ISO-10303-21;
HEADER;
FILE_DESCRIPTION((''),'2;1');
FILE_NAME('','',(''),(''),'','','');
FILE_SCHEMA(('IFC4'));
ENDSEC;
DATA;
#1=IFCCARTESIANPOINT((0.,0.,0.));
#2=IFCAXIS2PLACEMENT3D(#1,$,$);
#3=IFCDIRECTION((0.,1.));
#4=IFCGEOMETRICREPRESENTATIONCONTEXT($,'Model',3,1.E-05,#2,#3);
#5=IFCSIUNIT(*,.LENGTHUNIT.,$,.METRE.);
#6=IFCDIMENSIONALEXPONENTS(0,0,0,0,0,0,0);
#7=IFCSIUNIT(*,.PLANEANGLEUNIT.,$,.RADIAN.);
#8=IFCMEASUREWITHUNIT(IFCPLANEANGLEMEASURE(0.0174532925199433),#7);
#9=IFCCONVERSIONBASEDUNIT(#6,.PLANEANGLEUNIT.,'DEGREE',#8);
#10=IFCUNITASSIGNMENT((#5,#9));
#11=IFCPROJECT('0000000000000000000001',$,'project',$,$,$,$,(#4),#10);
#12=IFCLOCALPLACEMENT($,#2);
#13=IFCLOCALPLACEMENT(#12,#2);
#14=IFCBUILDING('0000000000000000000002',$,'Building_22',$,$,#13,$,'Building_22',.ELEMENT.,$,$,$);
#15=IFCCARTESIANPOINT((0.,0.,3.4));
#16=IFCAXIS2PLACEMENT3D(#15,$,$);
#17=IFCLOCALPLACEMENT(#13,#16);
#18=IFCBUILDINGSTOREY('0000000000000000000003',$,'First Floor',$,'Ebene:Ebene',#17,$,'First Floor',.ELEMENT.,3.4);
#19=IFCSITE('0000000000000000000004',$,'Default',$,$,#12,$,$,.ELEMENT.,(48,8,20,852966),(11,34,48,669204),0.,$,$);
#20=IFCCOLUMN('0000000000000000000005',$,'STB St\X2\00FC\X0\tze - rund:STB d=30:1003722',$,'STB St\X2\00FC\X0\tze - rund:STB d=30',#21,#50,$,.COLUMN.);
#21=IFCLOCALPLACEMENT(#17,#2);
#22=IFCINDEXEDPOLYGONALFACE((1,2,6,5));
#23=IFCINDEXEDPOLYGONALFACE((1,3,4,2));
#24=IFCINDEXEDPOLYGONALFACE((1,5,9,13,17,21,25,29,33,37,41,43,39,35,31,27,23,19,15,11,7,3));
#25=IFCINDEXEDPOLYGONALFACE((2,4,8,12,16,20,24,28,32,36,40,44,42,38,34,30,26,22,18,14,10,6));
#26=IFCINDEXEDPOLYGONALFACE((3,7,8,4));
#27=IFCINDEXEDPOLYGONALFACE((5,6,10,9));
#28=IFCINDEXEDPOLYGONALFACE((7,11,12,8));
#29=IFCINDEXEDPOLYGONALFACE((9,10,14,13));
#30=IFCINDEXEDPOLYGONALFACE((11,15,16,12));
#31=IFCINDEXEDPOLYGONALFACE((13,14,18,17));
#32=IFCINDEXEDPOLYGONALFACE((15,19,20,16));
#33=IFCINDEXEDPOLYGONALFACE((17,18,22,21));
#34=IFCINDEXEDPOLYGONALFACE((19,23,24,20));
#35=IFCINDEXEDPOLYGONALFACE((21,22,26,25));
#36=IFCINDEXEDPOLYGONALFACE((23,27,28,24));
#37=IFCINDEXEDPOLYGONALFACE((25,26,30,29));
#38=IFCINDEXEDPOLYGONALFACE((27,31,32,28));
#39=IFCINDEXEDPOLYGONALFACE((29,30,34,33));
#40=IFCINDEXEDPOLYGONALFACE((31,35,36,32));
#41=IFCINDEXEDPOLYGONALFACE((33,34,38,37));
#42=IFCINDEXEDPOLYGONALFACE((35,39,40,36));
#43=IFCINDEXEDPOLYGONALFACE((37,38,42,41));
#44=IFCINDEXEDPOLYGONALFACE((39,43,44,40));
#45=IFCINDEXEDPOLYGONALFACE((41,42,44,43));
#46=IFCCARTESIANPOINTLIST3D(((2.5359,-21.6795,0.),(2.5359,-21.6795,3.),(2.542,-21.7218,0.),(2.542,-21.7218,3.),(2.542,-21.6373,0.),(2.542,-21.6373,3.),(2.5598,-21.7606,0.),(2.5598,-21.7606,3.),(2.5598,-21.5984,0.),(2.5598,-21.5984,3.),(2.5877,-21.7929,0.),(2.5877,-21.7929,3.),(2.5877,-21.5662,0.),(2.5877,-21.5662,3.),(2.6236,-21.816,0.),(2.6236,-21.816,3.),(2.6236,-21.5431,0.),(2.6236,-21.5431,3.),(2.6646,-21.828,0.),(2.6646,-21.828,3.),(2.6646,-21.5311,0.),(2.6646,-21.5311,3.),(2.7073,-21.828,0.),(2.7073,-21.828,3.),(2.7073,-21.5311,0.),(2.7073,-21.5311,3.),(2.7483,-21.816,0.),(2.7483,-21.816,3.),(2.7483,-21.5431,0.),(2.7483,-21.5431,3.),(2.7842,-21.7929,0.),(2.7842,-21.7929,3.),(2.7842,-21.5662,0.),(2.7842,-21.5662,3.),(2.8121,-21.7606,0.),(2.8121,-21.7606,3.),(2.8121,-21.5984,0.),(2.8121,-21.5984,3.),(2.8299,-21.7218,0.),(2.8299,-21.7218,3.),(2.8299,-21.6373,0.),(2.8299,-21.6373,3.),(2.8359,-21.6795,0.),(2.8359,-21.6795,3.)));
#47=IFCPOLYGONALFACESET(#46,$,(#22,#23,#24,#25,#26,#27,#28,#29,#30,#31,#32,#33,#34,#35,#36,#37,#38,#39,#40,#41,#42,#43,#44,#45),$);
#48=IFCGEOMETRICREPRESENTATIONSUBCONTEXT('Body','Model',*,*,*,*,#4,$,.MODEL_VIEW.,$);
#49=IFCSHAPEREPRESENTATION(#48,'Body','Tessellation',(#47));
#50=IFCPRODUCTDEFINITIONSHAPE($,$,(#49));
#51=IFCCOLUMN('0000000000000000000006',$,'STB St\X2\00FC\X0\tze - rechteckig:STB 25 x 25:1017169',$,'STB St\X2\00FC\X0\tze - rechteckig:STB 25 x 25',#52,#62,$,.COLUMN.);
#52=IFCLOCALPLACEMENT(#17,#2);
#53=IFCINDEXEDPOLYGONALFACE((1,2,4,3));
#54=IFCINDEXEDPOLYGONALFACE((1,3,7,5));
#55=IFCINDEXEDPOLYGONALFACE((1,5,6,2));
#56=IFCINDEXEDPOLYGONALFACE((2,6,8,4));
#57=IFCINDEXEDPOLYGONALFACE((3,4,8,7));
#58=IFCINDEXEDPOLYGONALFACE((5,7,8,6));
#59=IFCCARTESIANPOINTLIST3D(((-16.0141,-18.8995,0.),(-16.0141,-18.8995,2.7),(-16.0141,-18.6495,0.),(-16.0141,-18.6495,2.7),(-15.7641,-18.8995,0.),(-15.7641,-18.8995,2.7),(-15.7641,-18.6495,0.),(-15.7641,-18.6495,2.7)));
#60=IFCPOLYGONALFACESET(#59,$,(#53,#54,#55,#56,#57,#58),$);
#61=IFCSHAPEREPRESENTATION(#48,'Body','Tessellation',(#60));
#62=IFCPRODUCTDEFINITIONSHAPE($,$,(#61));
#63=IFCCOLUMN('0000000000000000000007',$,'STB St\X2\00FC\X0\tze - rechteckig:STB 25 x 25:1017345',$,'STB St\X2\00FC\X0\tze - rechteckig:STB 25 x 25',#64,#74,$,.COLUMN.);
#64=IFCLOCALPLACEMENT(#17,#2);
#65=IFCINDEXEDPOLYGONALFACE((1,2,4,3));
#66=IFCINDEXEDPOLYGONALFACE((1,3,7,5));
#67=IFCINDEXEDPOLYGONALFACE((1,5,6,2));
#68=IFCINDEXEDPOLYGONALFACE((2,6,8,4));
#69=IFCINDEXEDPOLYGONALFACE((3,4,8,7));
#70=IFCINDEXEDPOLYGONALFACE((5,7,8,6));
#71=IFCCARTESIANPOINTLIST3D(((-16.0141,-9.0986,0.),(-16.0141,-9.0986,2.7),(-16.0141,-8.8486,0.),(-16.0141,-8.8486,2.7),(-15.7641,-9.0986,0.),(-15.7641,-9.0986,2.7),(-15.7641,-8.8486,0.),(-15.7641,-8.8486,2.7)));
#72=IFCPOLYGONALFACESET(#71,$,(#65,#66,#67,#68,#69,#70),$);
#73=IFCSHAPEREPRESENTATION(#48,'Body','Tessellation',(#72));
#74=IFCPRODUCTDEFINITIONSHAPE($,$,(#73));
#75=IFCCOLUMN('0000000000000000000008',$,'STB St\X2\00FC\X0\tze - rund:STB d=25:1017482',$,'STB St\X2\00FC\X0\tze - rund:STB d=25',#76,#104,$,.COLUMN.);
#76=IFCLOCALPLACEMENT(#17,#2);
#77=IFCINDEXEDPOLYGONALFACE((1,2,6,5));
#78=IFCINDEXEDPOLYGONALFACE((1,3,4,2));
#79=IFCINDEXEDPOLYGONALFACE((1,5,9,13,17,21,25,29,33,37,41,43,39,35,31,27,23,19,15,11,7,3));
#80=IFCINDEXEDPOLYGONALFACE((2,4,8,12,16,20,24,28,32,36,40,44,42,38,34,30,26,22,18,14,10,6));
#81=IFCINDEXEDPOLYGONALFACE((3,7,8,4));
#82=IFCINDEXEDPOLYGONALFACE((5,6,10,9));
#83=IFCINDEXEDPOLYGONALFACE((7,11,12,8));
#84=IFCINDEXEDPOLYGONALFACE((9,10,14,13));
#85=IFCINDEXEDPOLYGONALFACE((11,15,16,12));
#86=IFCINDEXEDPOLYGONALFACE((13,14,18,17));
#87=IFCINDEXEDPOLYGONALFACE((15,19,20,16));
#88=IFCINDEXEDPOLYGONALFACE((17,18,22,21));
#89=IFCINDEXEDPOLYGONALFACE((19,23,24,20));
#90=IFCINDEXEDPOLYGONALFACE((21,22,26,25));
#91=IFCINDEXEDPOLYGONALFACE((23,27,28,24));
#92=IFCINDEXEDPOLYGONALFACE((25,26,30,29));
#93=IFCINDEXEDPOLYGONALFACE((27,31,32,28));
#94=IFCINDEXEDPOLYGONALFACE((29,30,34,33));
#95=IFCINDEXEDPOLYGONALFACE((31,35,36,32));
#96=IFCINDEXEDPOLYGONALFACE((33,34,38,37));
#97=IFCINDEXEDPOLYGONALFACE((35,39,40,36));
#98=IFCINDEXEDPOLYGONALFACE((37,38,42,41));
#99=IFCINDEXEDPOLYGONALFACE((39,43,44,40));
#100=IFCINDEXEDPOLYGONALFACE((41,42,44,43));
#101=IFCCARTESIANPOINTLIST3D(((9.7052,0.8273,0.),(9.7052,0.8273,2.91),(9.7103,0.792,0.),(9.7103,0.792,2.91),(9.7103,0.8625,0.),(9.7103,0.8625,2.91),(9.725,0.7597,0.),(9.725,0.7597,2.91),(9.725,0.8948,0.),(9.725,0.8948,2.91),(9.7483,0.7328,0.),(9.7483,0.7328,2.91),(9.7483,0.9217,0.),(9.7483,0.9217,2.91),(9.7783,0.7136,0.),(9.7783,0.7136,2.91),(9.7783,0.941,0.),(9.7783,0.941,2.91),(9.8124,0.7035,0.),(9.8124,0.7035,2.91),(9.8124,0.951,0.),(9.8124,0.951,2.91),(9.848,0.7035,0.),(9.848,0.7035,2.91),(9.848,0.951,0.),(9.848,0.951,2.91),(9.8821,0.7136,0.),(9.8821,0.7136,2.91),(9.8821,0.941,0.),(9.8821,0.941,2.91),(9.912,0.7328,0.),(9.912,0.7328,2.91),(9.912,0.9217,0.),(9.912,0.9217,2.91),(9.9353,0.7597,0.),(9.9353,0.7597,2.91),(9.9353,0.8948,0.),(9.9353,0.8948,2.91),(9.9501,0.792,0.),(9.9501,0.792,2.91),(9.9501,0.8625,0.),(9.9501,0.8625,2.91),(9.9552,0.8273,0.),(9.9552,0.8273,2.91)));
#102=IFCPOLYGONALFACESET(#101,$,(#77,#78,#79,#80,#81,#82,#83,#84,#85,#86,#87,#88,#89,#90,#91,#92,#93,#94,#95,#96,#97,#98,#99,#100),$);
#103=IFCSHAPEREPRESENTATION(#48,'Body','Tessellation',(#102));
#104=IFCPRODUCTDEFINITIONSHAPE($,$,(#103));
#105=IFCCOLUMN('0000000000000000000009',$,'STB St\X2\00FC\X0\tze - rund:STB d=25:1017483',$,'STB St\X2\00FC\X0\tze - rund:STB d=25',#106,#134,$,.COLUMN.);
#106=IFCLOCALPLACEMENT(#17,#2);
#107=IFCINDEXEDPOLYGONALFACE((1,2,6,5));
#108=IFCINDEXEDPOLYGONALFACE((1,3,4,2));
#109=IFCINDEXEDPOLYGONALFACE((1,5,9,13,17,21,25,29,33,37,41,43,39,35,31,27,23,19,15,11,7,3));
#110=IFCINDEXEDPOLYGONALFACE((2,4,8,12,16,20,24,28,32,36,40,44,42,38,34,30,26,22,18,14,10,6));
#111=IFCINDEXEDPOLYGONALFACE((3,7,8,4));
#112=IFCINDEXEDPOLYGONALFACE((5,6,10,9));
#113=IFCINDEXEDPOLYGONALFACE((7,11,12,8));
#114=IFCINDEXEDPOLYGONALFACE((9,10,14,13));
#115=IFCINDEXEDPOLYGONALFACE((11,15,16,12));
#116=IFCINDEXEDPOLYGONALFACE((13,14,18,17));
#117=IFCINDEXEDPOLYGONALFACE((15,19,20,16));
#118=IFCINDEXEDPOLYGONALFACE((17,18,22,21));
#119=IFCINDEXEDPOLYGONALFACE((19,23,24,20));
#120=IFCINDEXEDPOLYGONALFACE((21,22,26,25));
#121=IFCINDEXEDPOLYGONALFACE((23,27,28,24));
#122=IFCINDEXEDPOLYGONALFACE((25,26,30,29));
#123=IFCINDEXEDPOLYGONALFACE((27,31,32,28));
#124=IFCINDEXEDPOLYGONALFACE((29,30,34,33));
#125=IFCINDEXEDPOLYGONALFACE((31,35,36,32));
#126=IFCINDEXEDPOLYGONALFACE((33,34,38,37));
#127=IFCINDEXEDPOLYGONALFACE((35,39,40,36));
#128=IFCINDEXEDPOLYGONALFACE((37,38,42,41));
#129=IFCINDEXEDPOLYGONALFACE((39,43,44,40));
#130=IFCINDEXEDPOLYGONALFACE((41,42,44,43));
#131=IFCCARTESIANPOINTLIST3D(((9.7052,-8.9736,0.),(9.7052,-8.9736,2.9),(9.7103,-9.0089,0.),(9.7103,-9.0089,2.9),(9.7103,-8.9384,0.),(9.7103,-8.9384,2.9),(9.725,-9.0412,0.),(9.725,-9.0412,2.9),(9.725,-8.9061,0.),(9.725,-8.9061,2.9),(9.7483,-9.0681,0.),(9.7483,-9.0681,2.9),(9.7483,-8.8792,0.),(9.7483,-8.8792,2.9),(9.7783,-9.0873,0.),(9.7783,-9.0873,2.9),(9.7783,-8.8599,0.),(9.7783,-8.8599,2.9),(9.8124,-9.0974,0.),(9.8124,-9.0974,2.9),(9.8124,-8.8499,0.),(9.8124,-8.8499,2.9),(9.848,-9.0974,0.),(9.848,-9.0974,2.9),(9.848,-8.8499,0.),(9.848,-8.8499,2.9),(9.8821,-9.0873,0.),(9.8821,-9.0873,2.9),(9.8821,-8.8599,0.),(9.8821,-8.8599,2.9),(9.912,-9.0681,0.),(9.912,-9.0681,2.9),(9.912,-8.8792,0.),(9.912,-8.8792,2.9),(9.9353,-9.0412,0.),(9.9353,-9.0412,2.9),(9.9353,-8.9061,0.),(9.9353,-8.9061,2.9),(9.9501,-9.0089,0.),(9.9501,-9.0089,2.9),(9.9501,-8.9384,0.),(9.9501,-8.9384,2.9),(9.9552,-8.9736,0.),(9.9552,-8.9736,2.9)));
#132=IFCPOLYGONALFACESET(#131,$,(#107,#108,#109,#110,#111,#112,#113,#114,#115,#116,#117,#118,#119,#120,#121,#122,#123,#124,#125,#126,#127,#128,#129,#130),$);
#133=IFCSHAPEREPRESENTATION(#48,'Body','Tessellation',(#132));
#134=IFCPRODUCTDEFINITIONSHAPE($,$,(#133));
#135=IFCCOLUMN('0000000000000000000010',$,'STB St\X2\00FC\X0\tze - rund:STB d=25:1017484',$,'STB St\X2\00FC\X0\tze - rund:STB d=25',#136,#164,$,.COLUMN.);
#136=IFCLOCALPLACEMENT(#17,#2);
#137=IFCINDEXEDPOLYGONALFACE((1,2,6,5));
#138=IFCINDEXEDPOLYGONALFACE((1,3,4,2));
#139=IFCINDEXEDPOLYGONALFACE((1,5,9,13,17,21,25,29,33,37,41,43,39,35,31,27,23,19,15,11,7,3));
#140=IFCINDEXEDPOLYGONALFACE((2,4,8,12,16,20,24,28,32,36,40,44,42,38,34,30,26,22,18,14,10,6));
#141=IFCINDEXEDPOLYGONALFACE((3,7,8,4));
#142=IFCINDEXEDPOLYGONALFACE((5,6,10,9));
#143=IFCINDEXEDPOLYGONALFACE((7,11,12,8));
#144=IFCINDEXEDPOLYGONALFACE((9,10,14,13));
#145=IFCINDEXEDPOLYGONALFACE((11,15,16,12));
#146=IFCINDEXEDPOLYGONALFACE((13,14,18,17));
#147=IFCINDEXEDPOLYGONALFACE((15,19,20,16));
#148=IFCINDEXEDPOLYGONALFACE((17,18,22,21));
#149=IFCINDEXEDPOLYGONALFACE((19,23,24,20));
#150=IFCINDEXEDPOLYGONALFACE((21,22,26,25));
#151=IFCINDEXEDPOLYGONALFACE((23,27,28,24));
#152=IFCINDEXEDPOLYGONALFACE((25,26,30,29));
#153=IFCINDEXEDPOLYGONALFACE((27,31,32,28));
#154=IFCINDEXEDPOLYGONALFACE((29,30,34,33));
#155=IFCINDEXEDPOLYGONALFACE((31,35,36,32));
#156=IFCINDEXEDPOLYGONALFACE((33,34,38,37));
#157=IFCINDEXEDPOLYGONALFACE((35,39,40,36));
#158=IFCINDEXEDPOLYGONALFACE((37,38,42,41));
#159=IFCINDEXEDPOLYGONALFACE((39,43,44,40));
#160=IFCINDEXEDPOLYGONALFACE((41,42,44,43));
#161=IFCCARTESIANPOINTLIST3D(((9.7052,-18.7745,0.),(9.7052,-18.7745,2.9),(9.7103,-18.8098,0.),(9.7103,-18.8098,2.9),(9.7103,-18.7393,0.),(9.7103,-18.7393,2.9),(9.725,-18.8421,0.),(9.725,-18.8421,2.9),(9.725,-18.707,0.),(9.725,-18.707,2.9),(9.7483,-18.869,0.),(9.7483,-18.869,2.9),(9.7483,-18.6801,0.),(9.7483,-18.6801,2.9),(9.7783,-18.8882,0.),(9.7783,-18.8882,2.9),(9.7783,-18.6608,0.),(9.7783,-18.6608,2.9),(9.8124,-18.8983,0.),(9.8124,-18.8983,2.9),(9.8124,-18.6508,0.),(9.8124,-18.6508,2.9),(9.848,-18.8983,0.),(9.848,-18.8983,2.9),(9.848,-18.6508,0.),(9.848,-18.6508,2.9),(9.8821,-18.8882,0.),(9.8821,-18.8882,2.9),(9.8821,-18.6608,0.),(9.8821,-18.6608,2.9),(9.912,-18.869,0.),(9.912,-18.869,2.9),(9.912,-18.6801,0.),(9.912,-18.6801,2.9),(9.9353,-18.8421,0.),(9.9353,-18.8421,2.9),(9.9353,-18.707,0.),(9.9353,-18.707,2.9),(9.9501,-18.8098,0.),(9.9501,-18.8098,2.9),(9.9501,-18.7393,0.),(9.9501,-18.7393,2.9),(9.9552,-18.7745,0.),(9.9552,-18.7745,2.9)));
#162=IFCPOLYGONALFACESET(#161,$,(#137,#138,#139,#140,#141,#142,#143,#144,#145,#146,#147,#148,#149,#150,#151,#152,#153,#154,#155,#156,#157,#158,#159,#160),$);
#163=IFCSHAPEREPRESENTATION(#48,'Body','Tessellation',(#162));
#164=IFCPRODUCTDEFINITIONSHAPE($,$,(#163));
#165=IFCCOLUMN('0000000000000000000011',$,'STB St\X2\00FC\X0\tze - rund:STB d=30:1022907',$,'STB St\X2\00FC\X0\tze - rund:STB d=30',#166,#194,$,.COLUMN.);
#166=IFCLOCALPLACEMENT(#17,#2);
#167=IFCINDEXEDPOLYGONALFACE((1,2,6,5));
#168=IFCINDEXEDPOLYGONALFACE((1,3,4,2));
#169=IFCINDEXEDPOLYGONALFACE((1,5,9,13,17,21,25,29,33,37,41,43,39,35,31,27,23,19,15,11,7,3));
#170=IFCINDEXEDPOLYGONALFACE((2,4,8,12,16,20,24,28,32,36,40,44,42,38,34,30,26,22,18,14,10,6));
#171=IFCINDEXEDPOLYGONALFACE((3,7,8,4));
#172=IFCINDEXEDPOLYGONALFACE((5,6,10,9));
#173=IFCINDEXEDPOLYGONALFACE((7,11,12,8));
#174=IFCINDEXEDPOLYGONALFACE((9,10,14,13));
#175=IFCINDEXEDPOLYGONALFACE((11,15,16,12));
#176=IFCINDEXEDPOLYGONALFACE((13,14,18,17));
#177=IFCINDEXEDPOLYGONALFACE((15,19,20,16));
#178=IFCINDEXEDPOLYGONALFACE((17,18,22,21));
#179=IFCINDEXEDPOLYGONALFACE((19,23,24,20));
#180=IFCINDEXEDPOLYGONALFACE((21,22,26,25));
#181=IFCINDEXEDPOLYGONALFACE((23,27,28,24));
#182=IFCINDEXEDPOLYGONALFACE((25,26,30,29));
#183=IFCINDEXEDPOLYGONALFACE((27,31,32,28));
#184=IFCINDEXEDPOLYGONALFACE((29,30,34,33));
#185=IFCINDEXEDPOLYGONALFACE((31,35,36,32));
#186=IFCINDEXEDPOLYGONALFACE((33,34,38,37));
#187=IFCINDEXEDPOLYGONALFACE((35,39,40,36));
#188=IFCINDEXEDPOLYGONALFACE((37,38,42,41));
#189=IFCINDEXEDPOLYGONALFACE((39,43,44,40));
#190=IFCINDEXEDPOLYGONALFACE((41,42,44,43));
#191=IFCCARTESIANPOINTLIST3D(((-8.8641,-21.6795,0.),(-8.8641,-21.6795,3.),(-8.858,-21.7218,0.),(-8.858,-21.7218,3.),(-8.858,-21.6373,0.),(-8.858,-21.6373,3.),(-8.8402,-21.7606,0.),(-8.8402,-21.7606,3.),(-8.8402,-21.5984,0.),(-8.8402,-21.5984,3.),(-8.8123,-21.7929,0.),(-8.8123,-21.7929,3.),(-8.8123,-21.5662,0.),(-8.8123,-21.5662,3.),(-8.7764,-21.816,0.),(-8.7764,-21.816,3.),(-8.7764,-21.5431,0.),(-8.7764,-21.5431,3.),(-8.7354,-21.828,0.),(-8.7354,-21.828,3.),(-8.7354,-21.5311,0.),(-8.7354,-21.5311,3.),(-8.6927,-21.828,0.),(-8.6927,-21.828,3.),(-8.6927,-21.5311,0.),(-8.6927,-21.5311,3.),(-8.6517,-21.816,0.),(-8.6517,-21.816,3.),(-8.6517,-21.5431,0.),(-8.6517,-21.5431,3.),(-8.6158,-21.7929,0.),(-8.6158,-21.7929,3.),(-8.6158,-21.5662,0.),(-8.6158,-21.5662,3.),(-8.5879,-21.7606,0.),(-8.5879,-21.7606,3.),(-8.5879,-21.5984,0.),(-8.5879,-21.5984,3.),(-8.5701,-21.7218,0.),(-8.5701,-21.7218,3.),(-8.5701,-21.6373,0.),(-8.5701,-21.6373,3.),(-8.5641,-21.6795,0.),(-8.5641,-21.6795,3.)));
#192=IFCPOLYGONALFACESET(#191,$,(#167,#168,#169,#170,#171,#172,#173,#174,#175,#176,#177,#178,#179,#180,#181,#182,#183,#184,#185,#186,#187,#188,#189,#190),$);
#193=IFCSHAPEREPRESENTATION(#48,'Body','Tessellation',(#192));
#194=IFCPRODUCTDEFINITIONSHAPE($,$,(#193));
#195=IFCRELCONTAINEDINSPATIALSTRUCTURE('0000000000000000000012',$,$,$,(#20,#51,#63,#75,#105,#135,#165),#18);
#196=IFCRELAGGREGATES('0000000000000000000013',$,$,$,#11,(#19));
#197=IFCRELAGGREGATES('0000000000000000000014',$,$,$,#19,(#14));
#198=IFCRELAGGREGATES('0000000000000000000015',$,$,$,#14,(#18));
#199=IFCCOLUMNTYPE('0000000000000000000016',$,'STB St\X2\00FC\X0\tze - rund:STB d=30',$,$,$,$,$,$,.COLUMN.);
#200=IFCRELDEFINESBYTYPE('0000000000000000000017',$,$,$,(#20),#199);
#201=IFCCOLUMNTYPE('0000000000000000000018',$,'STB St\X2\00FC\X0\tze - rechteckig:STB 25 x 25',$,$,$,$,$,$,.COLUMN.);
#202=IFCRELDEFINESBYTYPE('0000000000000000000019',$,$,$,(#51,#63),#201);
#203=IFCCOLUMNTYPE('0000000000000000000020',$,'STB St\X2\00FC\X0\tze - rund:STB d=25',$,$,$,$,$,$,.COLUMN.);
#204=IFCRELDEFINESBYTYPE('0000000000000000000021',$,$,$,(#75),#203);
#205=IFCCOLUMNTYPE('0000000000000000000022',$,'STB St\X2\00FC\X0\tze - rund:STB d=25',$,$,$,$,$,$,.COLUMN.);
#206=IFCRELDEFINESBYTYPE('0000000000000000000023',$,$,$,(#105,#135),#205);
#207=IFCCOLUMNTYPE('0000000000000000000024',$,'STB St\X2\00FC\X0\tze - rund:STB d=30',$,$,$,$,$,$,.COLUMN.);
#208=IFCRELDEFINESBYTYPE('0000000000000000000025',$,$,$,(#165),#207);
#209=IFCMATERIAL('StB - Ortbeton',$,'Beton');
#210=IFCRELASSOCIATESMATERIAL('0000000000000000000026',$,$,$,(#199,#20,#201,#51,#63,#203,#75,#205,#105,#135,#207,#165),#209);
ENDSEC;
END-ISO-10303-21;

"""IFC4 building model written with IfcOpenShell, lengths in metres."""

from ifc_helpers import new_model, entity, si_unit, converted_unit, direction, frame, origin, place, context, subcontext, project, spatial, arc, indexed_curve, outline, extrude, source, transform, mapped, material, type_object, type_shapes, element, save


model = new_model("IFC4")

# Units and contexts
model_context = context("Model", 3, precision=1e-05, world=origin(), true_north=direction((0.0, 1.0)))
body_context = subcontext(model_context, "Body", "Model", "MODEL_VIEW")
ifc_project = project(units=[si_unit("LENGTHUNIT", "METRE"), converted_unit("PLANEANGLEUNIT", "DEGREE", entity("IfcPlaneAngleMeasure", 0.0174532925199433), si_unit("PLANEANGLEUNIT", "RADIAN"), dimensions=[0, 0, 0, 0, 0, 0, 0])], contexts=[model_context])

# Site, building, storey
site_placement = place(None, origin())
site = spatial("IfcSite", under=ifc_project, at=site_placement, Name="Default", CompositionType="ELEMENT", RefLatitude=(48, 8, 20, 852966), RefLongitude=(11, 34, 48, 669204), RefElevation=0.0)
building_placement = place(site_placement, origin())
building = spatial("IfcBuilding", under=site, at=building_placement, Name="Building_22", LongName="Building_22", CompositionType="ELEMENT")
storey_placement = place(building_placement, frame((0.0, 0.0, 3.4)))
storey = spatial("IfcBuildingStorey", under=building, at=storey_placement, Name="First Floor", ObjectType="Ebene:Ebene", LongName="First Floor", CompositionType="ELEMENT", Elevation=3.4)

# Columns
ifc_material_1 = material(Name="StB - Ortbeton", Category="Beton")
column_type_1 = type_object("IfcColumnType", Name="STB Stütze - rund:STB d=30", PredefinedType="COLUMN", material=ifc_material_1)
shared_shape_1 = source(origin(), body_context, "Body", "SweptSolid", [
    extrude(outline(indexed_curve([(-0.15, 0.0), (0.0, -0.15), (0.15, 0.0), (0.0, 0.15)], segments=[arc(1, 2, 3), arc(3, 4, 1)], self_intersect=False)), frame((2.6859, -21.6795, 3.4), z_axis=(0.0, 0.0, 1.0), x_axis=(-1.0, 0.0, 0.0)), (0.0, 0.0, 1.0), 3.0),
])
type_shapes(column_type_1, [shared_shape_1])
column_1_placement = place(storey_placement, frame((0.0, 0.0, -3.4)))
element("IfcColumn", 1, at=column_1_placement, inside=storey, type_object=column_type_1, material=ifc_material_1, Name="STB Stütze - rund:STB d=30:1003722", ObjectType="STB Stütze - rund:STB d=30", PredefinedType="COLUMN", context=body_context, shape_type="MappedRepresentation", body=[
    mapped(shared_shape_1, transform((0.0, 0.0, 0.0), scale=1.0)),
])
column_type_2 = type_object("IfcColumnType", Name="STB Stütze - rechteckig:STB 25 x 25", PredefinedType="COLUMN", material=ifc_material_1)
shared_shape_2 = source(origin(), body_context, "Body", "SweptSolid", [
    extrude(outline(indexed_curve([(-0.125, -0.125), (0.125, -0.125), (0.125, 0.125), (-0.125, 0.125), (-0.125, -0.125)], self_intersect=False)), frame((0.0, 0.0, 3.4), z_axis=(0.0, 0.0, 1.0), x_axis=(-1.0, 0.0, 0.0)), (0.0, 0.0, 1.0), 2.7),
])
type_shapes(column_type_2, [shared_shape_2])
for number, where, name in (
    (2, (-15.8891, -18.7745, -3.4), "STB Stütze - rechteckig:STB 25 x 25:1017169"),
    (3, (-15.8891, -8.9736, -3.4), "STB Stütze - rechteckig:STB 25 x 25:1017345"),
):
    element("IfcColumn", number, at=place(storey_placement, frame(where)), inside=storey, type_object=column_type_2, material=ifc_material_1, Name=name, ObjectType="STB Stütze - rechteckig:STB 25 x 25", PredefinedType="COLUMN", context=body_context, shape_type="MappedRepresentation", body=[
        mapped(shared_shape_2, transform((0.0, 0.0, 0.0), scale=1.0)),
    ])
column_type_3 = type_object("IfcColumnType", Name="STB Stütze - rund:STB d=25", PredefinedType="COLUMN", material=ifc_material_1)
shared_shape_3 = source(origin(), body_context, "Body", "SweptSolid", [
    extrude(outline(indexed_curve([(-0.125, 0.0), (0.0, -0.125), (0.125, 0.0), (0.0, 0.125)], segments=[arc(1, 2, 3), arc(3, 4, 1)], self_intersect=False)), frame((9.8302, 0.8273, 3.4), z_axis=(0.0, 0.0, 1.0), x_axis=(-1.0, 0.0, 0.0)), (0.0, 0.0, 1.0), 2.91),
])
type_shapes(column_type_3, [shared_shape_3])
column_2_placement = place(storey_placement, frame((0.0, 0.0, -3.4)))
element("IfcColumn", 4, at=column_2_placement, inside=storey, type_object=column_type_3, material=ifc_material_1, Name="STB Stütze - rund:STB d=25:1017482", ObjectType="STB Stütze - rund:STB d=25", PredefinedType="COLUMN", context=body_context, shape_type="MappedRepresentation", body=[
    mapped(shared_shape_3, transform((0.0, 0.0, 0.0), scale=1.0)),
])
column_type_4 = type_object("IfcColumnType", Name="STB Stütze - rund:STB d=25", PredefinedType="COLUMN", material=ifc_material_1)
shared_shape_4 = source(origin(), body_context, "Body", "SweptSolid", [
    extrude(outline(indexed_curve([(-0.125, 0.0), (0.0, -0.125), (0.125, 0.0), (0.0, 0.125)], segments=[arc(1, 2, 3), arc(3, 4, 1)], self_intersect=False)), frame((0.0, 0.0, 3.4)), (0.0, 0.0, 1.0), 2.9),
])
type_shapes(column_type_4, [shared_shape_4])
for number, where, z_axis, x_axis, name in (
    (5, (9.8302, -8.9736, -3.4), (0.0, 0.0, 1.0), (-1.0, 0.0, 0.0), "STB Stütze - rund:STB d=25:1017483"),
    (6, (9.8302, -18.7745, -3.4), (0.0, 0.0, 1.0), (-1.0, 0.0, 0.0), "STB Stütze - rund:STB d=25:1017484"),
):
    element("IfcColumn", number, at=place(storey_placement, frame(where, z_axis=z_axis, x_axis=x_axis)), inside=storey, type_object=column_type_4, material=ifc_material_1, Name=name, ObjectType="STB Stütze - rund:STB d=25", PredefinedType="COLUMN", context=body_context, shape_type="MappedRepresentation", body=[
        mapped(shared_shape_4, transform((0.0, 0.0, 0.0), scale=1.0)),
    ])
column_type_5 = type_object("IfcColumnType", Name="STB Stütze - rund:STB d=30", PredefinedType="COLUMN", material=ifc_material_1)
shared_shape_5 = source(origin(), body_context, "Body", "SweptSolid", [
    extrude(outline(indexed_curve([(-0.15, 0.0), (0.0, -0.15), (0.15, 0.0), (0.0, 0.15)], segments=[arc(1, 2, 3), arc(3, 4, 1)], self_intersect=False)), frame((-8.7141, -21.6795, 3.4)), (0.0, 0.0, 1.0), 3.0),
])
type_shapes(column_type_5, [shared_shape_5])
column_3_placement = place(storey_placement, frame((0.0, 0.0, -3.4)))
element("IfcColumn", 7, at=column_3_placement, inside=storey, type_object=column_type_5, material=ifc_material_1, Name="STB Stütze - rund:STB d=30:1022907", ObjectType="STB Stütze - rund:STB d=30", PredefinedType="COLUMN", context=body_context, shape_type="MappedRepresentation", body=[
    mapped(shared_shape_5, transform((0.0, 0.0, 0.0), scale=1.0)),
])

save(model, "model.ifc")
